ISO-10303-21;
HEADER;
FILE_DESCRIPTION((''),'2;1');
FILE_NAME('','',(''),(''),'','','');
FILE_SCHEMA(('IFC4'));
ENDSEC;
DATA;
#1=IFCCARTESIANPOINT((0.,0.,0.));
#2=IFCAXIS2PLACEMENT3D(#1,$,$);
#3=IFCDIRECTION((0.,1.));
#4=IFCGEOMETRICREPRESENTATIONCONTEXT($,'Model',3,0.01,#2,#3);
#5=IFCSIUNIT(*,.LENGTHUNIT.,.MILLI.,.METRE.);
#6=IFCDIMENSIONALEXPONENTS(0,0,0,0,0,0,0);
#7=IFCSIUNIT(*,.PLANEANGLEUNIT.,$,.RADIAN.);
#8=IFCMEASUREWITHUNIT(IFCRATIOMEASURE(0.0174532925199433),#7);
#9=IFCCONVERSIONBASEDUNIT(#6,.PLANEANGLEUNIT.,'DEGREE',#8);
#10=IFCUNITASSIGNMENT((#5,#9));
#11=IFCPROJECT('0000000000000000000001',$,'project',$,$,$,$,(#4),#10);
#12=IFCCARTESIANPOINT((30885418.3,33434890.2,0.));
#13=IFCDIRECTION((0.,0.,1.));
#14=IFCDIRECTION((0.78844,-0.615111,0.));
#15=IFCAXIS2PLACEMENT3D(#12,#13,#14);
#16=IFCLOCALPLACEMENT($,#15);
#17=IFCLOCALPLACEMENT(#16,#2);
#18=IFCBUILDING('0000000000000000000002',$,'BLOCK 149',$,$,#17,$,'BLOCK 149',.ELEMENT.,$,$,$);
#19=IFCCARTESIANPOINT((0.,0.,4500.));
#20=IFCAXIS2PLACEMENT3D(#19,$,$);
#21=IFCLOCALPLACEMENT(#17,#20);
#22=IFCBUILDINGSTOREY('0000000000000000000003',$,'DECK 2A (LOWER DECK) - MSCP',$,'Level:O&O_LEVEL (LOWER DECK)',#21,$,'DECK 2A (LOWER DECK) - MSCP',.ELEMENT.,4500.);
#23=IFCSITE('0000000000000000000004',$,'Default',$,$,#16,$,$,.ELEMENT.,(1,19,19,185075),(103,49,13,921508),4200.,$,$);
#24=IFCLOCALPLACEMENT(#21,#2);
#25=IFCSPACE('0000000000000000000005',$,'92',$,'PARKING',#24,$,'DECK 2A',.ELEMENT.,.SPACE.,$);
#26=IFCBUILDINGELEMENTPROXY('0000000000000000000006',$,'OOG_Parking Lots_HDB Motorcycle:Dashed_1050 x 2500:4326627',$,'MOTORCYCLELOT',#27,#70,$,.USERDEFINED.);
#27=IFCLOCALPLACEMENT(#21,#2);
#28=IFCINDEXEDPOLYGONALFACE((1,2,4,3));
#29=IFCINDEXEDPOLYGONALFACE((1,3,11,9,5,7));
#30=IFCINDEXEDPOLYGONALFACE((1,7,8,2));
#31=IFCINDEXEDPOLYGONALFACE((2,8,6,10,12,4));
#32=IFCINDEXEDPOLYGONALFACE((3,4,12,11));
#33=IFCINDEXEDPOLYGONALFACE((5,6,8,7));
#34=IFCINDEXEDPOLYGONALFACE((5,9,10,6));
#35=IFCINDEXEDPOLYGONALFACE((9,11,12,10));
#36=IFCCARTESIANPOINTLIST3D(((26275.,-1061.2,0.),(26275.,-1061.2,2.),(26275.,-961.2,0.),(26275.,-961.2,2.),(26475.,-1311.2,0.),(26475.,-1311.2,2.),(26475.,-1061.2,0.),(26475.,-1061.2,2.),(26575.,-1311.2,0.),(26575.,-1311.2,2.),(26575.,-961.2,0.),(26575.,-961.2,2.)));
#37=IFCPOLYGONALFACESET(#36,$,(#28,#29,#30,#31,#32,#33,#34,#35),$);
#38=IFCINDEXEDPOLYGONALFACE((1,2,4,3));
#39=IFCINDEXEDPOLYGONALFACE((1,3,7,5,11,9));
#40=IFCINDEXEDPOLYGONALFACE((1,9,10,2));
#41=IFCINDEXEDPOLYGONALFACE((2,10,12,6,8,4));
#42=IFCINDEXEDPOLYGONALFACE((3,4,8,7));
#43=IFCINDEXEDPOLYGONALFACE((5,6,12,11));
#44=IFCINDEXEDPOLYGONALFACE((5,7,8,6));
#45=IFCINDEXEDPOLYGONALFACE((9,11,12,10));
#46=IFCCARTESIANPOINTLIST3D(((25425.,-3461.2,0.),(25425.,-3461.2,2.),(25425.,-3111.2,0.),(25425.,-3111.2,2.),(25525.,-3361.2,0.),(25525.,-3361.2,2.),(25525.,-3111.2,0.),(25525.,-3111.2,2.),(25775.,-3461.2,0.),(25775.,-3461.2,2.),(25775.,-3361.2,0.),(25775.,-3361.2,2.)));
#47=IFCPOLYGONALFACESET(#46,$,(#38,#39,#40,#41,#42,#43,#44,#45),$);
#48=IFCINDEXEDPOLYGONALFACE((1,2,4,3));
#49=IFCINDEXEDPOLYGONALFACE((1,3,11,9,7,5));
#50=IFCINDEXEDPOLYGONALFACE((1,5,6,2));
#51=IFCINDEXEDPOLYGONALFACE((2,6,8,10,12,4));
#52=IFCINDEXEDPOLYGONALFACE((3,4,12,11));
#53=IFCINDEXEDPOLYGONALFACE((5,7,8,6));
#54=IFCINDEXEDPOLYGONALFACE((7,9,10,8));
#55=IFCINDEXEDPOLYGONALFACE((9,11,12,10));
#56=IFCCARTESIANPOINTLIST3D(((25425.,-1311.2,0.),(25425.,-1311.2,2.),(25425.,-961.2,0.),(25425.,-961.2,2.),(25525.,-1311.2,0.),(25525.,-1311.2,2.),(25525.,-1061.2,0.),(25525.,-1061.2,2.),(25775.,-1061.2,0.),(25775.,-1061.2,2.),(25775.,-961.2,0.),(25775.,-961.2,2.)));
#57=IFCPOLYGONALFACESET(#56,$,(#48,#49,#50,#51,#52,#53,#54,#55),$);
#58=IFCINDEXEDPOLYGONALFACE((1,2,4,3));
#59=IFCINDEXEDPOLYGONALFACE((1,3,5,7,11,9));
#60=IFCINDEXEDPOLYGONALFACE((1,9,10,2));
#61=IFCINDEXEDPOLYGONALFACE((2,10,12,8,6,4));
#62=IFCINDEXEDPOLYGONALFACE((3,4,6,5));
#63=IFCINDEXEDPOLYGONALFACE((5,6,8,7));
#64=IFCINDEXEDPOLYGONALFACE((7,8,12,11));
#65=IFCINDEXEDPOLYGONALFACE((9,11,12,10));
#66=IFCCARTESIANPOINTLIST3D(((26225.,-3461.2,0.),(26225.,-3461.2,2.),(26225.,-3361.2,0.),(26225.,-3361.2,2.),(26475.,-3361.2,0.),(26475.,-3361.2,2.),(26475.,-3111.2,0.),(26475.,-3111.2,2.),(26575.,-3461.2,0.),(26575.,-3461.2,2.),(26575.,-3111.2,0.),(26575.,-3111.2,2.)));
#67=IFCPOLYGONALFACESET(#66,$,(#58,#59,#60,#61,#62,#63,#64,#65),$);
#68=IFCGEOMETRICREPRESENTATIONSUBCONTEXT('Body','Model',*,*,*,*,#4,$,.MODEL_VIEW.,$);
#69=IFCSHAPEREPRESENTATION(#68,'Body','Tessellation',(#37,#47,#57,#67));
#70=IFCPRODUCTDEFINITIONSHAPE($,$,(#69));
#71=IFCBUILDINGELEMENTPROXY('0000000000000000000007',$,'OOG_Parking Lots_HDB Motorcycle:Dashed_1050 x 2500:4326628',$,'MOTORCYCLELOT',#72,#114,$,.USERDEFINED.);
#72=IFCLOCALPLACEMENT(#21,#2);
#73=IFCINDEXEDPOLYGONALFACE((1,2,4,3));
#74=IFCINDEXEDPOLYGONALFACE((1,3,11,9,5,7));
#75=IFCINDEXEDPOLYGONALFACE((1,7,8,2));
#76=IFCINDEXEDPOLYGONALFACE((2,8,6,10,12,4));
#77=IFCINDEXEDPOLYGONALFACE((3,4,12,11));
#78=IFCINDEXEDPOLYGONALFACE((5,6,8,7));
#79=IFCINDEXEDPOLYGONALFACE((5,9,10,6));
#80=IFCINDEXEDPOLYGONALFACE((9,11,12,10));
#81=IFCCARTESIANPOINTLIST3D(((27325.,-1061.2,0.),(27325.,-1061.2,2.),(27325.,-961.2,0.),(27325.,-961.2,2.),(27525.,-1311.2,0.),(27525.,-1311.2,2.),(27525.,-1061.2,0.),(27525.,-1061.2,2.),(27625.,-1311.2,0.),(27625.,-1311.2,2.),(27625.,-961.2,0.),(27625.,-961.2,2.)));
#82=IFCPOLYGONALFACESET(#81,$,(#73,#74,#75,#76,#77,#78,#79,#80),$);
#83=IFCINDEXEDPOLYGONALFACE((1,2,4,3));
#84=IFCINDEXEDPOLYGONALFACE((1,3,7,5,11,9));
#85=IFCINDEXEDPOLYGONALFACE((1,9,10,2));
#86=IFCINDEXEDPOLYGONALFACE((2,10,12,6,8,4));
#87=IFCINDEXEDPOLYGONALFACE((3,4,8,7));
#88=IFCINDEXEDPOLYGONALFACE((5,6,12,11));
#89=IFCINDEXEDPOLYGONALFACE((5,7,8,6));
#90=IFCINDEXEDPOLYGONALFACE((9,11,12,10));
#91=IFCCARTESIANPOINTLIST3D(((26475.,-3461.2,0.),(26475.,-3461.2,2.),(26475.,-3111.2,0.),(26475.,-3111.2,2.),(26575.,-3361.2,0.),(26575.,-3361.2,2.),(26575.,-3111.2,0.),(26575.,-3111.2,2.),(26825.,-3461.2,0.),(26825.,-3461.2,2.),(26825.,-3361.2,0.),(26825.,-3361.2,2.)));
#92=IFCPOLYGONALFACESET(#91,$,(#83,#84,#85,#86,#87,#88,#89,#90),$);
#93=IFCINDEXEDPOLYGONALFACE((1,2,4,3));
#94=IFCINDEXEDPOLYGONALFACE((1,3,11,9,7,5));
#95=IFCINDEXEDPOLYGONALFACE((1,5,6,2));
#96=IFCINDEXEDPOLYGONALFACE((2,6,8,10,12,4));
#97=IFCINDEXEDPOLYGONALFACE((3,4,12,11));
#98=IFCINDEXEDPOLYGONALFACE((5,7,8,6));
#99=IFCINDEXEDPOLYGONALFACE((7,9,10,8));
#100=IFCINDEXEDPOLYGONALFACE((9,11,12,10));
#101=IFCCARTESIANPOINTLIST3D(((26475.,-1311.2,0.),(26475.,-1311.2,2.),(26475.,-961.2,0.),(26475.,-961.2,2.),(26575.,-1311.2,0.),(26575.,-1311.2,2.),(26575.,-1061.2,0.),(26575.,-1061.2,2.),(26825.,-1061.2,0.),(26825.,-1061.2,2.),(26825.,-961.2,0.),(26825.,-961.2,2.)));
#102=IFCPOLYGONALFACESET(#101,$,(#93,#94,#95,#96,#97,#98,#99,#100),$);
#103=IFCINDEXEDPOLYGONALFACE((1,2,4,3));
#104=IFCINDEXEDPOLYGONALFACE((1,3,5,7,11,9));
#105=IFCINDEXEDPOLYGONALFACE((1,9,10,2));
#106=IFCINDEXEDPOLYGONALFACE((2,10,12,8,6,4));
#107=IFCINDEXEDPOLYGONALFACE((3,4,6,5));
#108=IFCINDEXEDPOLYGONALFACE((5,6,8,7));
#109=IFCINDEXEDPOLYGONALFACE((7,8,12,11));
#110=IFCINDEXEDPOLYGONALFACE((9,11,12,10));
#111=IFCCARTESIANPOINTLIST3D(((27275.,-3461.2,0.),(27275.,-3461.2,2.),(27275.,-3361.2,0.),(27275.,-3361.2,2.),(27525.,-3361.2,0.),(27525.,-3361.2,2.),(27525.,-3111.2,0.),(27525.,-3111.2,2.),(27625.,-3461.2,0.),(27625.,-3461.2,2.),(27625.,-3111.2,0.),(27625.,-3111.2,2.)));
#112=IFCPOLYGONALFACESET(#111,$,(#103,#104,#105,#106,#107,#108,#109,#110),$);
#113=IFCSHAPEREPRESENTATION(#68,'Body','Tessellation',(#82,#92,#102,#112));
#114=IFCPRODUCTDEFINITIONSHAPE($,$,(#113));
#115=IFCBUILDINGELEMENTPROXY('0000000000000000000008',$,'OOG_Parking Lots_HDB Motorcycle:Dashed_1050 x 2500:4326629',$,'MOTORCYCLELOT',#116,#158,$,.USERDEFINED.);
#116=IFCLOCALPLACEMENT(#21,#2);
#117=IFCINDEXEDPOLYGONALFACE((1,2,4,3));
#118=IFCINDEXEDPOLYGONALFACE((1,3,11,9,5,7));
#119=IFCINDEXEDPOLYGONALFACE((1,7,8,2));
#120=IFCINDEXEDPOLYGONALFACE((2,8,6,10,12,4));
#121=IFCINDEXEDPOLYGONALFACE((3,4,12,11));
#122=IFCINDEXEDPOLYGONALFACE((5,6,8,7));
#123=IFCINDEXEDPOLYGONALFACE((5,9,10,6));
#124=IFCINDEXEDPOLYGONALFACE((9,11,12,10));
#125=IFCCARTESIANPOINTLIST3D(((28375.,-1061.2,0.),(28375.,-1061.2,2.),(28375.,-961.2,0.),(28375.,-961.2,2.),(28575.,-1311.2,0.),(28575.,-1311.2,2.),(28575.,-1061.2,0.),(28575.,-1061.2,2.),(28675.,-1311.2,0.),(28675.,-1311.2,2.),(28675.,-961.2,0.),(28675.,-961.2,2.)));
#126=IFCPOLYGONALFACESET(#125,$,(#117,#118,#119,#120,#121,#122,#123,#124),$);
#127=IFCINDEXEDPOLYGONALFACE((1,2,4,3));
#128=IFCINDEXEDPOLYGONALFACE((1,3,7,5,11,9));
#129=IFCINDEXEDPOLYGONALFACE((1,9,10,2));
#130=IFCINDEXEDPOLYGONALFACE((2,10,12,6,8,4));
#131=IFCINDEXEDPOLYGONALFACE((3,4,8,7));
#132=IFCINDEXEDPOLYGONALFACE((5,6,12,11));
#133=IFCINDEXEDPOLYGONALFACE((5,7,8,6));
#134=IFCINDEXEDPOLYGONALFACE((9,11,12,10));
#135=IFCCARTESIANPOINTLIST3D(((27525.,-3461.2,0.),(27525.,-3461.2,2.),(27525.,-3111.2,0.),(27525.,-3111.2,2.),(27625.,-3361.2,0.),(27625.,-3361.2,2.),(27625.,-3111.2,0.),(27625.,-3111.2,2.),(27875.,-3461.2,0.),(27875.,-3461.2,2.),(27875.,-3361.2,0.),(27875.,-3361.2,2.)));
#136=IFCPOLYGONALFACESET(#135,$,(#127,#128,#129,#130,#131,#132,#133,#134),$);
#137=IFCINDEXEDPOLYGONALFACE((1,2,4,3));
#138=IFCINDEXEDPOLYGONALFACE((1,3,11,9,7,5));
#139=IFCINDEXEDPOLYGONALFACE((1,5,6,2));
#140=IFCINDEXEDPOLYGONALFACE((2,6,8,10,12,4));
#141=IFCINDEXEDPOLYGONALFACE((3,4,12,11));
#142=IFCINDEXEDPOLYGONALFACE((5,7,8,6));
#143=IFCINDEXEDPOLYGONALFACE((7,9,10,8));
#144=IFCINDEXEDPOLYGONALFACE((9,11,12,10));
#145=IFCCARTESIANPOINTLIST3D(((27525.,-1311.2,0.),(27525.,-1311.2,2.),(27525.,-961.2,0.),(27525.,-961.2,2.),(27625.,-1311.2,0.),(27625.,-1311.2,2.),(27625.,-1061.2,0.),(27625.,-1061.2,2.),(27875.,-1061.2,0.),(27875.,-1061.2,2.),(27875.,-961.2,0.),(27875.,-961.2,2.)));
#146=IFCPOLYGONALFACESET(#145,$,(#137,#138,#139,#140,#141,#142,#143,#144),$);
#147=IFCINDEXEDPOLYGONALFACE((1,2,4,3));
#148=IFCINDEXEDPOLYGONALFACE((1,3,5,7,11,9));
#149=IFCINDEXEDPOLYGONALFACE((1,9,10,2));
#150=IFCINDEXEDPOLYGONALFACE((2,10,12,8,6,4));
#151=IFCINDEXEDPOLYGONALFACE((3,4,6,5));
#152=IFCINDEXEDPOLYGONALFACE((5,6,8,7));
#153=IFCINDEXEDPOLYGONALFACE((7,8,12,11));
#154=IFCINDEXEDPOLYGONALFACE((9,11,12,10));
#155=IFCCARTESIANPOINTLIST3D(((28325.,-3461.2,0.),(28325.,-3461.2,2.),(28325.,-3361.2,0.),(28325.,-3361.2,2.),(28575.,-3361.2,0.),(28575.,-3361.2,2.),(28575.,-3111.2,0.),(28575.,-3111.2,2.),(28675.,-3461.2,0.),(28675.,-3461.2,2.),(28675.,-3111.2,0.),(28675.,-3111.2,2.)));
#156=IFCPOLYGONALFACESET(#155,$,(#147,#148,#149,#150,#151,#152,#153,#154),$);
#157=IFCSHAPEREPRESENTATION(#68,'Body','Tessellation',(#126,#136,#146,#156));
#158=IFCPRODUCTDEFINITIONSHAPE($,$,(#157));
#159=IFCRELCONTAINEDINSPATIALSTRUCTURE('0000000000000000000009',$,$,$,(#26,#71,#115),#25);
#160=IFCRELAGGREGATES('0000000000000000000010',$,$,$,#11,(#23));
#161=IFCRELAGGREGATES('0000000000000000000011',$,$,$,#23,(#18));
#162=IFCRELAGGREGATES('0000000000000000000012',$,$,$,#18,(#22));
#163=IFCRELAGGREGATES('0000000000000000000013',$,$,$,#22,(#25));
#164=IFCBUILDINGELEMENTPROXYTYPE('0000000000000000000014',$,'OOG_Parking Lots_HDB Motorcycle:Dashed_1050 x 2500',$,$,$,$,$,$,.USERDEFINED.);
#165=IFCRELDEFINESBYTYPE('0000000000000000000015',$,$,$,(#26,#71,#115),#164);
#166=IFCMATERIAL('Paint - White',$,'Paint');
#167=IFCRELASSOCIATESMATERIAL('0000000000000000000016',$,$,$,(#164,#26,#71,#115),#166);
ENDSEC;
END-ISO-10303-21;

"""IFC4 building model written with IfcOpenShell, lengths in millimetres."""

from ifc_helpers import new_model, entity, si_unit, converted_unit, direction, frame, origin, place, context, subcontext, project, spatial, indexed_curve, outline, extrude, source, transform, mapped, material, type_object, type_shapes, element, save


model = new_model("IFC4")

# Units and contexts
model_context = context("Model", 3, precision=0.01, world=origin(), true_north=direction((0.0, 1.0)))
body_context = subcontext(model_context, "Body", "Model", "MODEL_VIEW")
ifc_project = project(units=[si_unit("LENGTHUNIT", "METRE", prefix="MILLI"), converted_unit("PLANEANGLEUNIT", "DEGREE", entity("IfcRatioMeasure", 0.0174532925199433), si_unit("PLANEANGLEUNIT", "RADIAN"), dimensions=[0, 0, 0, 0, 0, 0, 0])], contexts=[model_context])

# Site, building, storey
site_placement = place(None, frame((30885418.3, 33434890.2, 0.0), z_axis=(0.0, 0.0, 1.0), x_axis=(0.78844, -0.615111, 0.0)))
site = spatial("IfcSite", under=ifc_project, at=site_placement, Name="Default", CompositionType="ELEMENT", RefLatitude=(1, 19, 19, 185075), RefLongitude=(103, 49, 13, 921508), RefElevation=4200.0)
building_placement = place(site_placement, origin())
building = spatial("IfcBuilding", under=site, at=building_placement, Name="BLOCK 149", LongName="BLOCK 149", CompositionType="ELEMENT")
storey_placement = place(building_placement, frame((0.0, 0.0, 4500.0)))
storey = spatial("IfcBuildingStorey", under=building, at=storey_placement, Name="DECK 2A (LOWER DECK) - MSCP", ObjectType="Level:O&O_LEVEL (LOWER DECK)", LongName="DECK 2A (LOWER DECK) - MSCP", CompositionType="ELEMENT", Elevation=4500.0)

# Shared definitions
space_placement = place(storey_placement, origin())
space = spatial("IfcSpace", under=storey, at=space_placement, Name="92", ObjectType="PARKING", LongName="DECK 2A", CompositionType="ELEMENT", PredefinedType="SPACE")

# Building element proxies
ifc_material_1 = material(Name="Paint - White", Category="Paint")
building_element_proxy_type_1 = type_object("IfcBuildingElementProxyType", Name="OOG_Parking Lots_HDB Motorcycle:Dashed_1050 x 2500", PredefinedType="USERDEFINED", material=ifc_material_1)
shared_shape_1 = source(origin(), body_context, "Body", "SweptSolid", [
    extrude(outline(indexed_curve([(-200.0, -133.3), (150.0, -133.3), (150.0, 166.7), (50.0, 166.7), (50.0, -33.3), (-200.0, -33.3), (-200.0, -133.3)], self_intersect=False)), frame((966.7, -100.0, 0.0), z_axis=(0.0, 0.0, 1.0), x_axis=(0.0, 1.0, 0.0)), (0.0, 0.0, 1.0), 2.0),
    extrude(outline(indexed_curve([(-200.0, -150.0), (150.0, -150.0), (150.0, 200.0), (50.0, 200.0), (50.0, -50.0), (-200.0, -50.0), (-200.0, -150.0)], self_intersect=False)), frame((100.0, -2300.0, 0.0), z_axis=(0.0, 0.0, 1.0), x_axis=(0.0, -1.0, 0.0)), (0.0, 0.0, 1.0), 2.0),
    extrude(outline(indexed_curve([(-200.0, -150.0), (150.0, -150.0), (150.0, 200.0), (50.0, 200.0), (50.0, -50.0), (-200.0, -50.0), (-200.0, -150.0)], self_intersect=False)), frame((100.0, -100.0, 0.0), z_axis=(0.0, 0.0, 1.0), x_axis=(-1.0, 0.0, 0.0)), (0.0, 0.0, 1.0), 2.0),
    extrude(outline(indexed_curve([(-200.0, -150.0), (150.0, -150.0), (150.0, 200.0), (50.0, 200.0), (50.0, -50.0), (-200.0, -50.0), (-200.0, -150.0)], self_intersect=False)), frame((950.0, -2300.0, 0.0)), (0.0, 0.0, 1.0), 2.0),
])
type_shapes(building_element_proxy_type_1, [shared_shape_1])
for number, where, name in (
    (1, (25475.0, -1011.2, 0.0), "OOG_Parking Lots_HDB Motorcycle:Dashed_1050 x 2500:4326627"),
    (2, (26525.0, -1011.2, 0.0), "OOG_Parking Lots_HDB Motorcycle:Dashed_1050 x 2500:4326628"),
    (3, (27575.0, -1011.2, 0.0), "OOG_Parking Lots_HDB Motorcycle:Dashed_1050 x 2500:4326629"),
):
    element("IfcBuildingElementProxy", number, at=place(space_placement, frame(where)), inside=space, type_object=building_element_proxy_type_1, material=ifc_material_1, Name=name, ObjectType="MOTORCYCLELOT", PredefinedType="USERDEFINED", context=body_context, shape_type="MappedRepresentation", body=[
        mapped(shared_shape_1, transform((0.0, 0.0, 0.0), scale=1.0)),
    ])

save(model, "model.ifc")
